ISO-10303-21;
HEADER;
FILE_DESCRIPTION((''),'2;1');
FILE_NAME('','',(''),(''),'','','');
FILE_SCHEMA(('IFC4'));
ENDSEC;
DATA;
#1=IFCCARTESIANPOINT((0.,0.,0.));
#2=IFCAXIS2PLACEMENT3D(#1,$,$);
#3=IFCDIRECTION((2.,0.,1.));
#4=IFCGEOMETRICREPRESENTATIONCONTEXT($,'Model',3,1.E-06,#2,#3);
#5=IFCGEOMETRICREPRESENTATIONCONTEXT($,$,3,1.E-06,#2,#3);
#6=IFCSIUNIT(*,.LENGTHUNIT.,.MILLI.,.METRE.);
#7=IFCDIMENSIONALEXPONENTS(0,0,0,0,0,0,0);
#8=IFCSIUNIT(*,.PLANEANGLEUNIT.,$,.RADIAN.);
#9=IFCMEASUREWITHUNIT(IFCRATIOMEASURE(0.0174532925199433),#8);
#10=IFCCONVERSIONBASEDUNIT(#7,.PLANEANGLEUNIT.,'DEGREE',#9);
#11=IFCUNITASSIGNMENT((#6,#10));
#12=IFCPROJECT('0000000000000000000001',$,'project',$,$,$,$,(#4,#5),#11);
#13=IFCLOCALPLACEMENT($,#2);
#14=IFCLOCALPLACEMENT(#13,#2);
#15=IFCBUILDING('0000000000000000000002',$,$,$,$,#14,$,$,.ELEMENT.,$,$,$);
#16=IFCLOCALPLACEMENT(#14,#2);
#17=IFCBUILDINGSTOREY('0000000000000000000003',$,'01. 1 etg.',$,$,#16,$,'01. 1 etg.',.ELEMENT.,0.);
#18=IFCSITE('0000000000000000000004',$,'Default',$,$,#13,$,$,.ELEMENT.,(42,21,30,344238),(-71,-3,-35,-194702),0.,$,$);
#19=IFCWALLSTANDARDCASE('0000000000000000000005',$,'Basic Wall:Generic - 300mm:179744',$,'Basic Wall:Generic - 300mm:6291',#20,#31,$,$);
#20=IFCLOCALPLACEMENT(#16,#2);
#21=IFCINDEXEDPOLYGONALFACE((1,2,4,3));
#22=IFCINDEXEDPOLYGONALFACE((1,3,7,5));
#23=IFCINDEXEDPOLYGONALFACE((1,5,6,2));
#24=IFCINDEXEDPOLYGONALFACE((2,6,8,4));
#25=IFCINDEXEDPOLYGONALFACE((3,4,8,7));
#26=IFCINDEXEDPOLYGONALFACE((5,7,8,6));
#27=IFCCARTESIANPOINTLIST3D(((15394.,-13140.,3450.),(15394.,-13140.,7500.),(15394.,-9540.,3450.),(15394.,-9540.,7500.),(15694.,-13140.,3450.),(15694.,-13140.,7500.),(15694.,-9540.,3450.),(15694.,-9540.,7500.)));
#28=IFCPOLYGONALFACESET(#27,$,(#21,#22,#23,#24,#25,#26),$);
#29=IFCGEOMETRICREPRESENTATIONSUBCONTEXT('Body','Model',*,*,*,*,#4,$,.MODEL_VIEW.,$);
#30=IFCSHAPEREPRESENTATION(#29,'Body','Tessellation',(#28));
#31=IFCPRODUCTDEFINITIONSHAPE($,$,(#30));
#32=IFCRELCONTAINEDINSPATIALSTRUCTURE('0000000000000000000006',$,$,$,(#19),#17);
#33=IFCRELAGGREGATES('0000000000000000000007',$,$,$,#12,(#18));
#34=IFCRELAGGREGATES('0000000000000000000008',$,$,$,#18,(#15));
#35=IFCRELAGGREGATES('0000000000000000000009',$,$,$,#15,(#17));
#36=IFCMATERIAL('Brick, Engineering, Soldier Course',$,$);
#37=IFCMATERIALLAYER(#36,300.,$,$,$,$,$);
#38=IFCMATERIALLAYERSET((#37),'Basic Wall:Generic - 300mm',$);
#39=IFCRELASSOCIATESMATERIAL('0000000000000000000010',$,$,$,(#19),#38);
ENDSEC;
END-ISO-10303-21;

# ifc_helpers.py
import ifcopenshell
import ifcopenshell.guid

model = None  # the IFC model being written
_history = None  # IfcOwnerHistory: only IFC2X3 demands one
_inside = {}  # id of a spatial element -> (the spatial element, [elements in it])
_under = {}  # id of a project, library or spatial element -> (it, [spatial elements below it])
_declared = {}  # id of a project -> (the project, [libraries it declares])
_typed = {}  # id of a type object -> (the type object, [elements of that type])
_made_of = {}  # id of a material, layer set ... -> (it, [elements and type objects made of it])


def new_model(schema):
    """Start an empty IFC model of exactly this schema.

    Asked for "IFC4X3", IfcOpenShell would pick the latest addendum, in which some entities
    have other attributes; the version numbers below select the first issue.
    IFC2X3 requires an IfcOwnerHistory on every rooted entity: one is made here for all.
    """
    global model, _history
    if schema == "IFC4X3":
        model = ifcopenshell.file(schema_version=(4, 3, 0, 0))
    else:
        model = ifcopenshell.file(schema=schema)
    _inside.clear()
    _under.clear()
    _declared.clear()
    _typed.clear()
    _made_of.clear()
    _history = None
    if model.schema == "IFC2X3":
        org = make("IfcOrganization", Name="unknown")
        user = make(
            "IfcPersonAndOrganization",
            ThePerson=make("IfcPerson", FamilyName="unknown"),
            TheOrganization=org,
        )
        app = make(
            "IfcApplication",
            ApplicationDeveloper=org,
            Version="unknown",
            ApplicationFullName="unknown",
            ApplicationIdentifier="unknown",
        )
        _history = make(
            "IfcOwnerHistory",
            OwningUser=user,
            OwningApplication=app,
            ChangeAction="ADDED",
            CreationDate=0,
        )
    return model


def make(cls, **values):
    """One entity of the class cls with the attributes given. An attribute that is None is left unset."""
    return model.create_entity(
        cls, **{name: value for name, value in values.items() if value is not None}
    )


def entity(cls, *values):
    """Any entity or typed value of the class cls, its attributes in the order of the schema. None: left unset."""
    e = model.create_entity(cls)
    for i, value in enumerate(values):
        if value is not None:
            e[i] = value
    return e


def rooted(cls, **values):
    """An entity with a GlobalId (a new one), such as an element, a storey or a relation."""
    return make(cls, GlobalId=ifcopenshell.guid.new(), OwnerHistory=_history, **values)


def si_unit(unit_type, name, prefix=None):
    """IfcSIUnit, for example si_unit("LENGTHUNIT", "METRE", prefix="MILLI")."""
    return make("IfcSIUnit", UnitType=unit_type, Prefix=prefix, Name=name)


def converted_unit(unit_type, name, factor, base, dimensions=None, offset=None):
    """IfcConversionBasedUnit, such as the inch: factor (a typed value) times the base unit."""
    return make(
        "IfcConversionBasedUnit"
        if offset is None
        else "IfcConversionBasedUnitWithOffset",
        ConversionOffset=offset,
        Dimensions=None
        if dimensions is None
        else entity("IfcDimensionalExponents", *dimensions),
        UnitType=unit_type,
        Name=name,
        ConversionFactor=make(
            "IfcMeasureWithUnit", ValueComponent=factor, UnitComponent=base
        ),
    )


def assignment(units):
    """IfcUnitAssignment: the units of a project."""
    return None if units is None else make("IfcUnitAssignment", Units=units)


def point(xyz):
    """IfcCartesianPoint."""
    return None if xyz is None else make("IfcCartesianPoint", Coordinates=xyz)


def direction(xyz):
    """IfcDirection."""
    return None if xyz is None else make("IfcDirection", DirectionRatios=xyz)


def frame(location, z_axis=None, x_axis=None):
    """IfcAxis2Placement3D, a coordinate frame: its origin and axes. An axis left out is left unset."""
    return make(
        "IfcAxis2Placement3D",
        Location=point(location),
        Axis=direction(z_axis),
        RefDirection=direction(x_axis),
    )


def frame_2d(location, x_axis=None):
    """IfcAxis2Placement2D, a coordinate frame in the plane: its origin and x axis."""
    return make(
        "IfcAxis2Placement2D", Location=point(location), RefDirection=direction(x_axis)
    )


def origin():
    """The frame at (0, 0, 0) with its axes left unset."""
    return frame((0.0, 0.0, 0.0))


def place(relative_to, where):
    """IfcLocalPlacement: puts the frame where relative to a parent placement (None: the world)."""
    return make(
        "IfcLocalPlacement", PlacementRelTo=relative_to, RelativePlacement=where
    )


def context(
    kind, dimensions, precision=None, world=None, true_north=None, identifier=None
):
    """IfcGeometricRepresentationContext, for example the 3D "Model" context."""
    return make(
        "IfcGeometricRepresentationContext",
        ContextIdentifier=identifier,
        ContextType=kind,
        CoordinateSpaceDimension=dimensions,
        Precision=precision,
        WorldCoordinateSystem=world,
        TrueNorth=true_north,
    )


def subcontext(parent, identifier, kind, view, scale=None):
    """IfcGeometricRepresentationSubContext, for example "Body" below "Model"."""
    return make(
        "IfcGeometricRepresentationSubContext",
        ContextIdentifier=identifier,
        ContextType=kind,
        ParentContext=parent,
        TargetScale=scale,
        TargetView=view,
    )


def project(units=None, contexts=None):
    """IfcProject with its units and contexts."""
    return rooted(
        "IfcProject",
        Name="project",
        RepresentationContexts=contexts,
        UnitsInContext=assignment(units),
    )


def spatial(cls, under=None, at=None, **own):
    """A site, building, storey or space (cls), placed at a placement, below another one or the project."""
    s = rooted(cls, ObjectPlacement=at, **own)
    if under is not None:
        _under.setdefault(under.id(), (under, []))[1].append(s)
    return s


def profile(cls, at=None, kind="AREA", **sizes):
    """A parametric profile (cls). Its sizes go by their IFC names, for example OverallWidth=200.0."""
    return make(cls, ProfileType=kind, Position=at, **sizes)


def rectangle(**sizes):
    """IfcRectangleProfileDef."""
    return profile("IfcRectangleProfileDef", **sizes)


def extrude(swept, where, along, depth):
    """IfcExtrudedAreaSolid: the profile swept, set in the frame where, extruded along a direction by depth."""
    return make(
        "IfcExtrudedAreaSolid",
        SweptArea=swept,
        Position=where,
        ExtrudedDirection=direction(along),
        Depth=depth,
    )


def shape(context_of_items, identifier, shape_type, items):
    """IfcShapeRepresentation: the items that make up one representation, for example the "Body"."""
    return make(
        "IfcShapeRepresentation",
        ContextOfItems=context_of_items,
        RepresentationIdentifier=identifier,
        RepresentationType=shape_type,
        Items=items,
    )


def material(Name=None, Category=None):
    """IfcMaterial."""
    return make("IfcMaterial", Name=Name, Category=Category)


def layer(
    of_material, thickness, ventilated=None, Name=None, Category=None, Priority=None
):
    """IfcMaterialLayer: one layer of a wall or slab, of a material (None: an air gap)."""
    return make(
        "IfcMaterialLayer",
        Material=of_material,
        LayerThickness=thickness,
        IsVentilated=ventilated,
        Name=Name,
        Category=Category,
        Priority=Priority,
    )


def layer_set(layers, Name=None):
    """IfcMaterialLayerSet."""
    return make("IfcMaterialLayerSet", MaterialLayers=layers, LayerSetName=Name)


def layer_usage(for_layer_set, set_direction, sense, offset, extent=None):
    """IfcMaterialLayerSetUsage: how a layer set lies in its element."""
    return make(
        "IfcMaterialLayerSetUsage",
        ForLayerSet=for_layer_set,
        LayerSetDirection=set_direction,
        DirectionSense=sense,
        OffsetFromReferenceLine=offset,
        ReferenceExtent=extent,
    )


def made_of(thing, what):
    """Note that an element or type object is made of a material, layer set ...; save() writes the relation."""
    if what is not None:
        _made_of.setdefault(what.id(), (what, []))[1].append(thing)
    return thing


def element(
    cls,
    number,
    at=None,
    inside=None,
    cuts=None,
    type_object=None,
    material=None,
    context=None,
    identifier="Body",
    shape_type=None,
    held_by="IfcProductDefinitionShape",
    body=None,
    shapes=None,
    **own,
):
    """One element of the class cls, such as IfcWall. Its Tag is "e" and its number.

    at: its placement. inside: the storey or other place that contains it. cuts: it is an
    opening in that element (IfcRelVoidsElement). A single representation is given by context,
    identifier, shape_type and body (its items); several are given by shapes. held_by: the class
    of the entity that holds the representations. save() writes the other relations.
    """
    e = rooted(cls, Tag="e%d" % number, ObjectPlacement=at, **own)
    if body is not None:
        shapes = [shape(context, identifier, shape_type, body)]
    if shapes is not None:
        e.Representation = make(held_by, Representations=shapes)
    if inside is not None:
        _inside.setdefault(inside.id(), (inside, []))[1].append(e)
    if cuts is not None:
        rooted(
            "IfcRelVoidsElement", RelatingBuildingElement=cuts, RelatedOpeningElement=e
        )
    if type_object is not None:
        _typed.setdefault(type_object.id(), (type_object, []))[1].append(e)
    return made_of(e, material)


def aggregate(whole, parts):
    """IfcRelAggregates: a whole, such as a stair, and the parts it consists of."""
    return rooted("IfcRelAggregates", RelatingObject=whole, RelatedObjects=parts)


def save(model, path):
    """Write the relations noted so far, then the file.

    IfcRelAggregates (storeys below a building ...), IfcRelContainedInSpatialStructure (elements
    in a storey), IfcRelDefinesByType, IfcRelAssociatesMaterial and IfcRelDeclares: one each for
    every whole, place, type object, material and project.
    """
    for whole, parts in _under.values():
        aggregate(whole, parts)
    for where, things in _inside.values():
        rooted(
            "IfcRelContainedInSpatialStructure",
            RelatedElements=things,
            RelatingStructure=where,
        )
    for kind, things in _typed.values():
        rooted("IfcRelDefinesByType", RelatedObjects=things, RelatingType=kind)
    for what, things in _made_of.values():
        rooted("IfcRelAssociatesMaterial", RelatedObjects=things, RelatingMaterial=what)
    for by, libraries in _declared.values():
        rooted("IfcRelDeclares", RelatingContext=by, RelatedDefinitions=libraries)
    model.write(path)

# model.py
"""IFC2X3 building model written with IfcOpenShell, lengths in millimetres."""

from ifc_helpers import new_model, entity, si_unit, converted_unit, direction, frame, frame_2d, origin, place, context, subcontext, project, spatial, rectangle, extrude, material, layer, layer_set, layer_usage, element, save


model = new_model("IFC2X3")

# Units and contexts
model_context = context("Model", 3, precision=1e-06, world=origin(), true_north=direction((2.0, 0.0, 1.0)))
context_of_model = context(None, 3, precision=1e-06, world=origin(), true_north=direction((2.0, 0.0, 1.0)))
body_context = subcontext(model_context, "Body", "Model", "MODEL_VIEW")
ifc_project = project(units=[si_unit("LENGTHUNIT", "METRE", prefix="MILLI"), converted_unit("PLANEANGLEUNIT", "DEGREE", entity("IfcRatioMeasure", 0.0174532925199433), si_unit("PLANEANGLEUNIT", "RADIAN"), dimensions=[0, 0, 0, 0, 0, 0, 0])], contexts=[model_context, context_of_model])

# Site, building, storey
site_placement = place(None, origin())
site = spatial("IfcSite", under=ifc_project, at=site_placement, Name="Default", CompositionType="ELEMENT", RefLatitude=(42, 21, 30, 344238), RefLongitude=(-71, -3, -35, -194702), RefElevation=0.0)
building_placement = place(site_placement, origin())
building = spatial("IfcBuilding", under=site, at=building_placement, CompositionType="ELEMENT")
storey_placement = place(building_placement, origin())
storey = spatial("IfcBuildingStorey", under=building, at=storey_placement, Name="01. 1 etg.", LongName="01. 1 etg.", CompositionType="ELEMENT", Elevation=0.0)

# Shared definitions
ifc_material_1 = material(Name="Brick, Engineering, Soldier Course")
ifc_layer_1 = layer(ifc_material_1, 300.0)
ifc_layer_set_1 = layer_set([ifc_layer_1], Name="Basic Wall:Generic - 300mm")

# Wall
ifc_layer_usage_1 = layer_usage(ifc_layer_set_1, "AXIS2", "POSITIVE", -150.0)
wall_1_placement = place(storey_placement, frame((15544.0, -13140.0, 3450.0), z_axis=(0.0, 0.0, 1.0), x_axis=(0.0, 1.0, 0.0)))
element("IfcWallStandardCase", 1, at=wall_1_placement, inside=storey, material=ifc_layer_usage_1, Name="Basic Wall:Generic - 300mm:179744", ObjectType="Basic Wall:Generic - 300mm:6291", context=body_context, shape_type="SweptSolid", body=[
    extrude(rectangle(XDim=3600.0, YDim=300.0, at=frame_2d((1800.0, 0.0), x_axis=(-1.0, 0.0))), origin(), (0.0, 0.0, 1.0), 4050.0),
])

save(model, "model.ifc")
